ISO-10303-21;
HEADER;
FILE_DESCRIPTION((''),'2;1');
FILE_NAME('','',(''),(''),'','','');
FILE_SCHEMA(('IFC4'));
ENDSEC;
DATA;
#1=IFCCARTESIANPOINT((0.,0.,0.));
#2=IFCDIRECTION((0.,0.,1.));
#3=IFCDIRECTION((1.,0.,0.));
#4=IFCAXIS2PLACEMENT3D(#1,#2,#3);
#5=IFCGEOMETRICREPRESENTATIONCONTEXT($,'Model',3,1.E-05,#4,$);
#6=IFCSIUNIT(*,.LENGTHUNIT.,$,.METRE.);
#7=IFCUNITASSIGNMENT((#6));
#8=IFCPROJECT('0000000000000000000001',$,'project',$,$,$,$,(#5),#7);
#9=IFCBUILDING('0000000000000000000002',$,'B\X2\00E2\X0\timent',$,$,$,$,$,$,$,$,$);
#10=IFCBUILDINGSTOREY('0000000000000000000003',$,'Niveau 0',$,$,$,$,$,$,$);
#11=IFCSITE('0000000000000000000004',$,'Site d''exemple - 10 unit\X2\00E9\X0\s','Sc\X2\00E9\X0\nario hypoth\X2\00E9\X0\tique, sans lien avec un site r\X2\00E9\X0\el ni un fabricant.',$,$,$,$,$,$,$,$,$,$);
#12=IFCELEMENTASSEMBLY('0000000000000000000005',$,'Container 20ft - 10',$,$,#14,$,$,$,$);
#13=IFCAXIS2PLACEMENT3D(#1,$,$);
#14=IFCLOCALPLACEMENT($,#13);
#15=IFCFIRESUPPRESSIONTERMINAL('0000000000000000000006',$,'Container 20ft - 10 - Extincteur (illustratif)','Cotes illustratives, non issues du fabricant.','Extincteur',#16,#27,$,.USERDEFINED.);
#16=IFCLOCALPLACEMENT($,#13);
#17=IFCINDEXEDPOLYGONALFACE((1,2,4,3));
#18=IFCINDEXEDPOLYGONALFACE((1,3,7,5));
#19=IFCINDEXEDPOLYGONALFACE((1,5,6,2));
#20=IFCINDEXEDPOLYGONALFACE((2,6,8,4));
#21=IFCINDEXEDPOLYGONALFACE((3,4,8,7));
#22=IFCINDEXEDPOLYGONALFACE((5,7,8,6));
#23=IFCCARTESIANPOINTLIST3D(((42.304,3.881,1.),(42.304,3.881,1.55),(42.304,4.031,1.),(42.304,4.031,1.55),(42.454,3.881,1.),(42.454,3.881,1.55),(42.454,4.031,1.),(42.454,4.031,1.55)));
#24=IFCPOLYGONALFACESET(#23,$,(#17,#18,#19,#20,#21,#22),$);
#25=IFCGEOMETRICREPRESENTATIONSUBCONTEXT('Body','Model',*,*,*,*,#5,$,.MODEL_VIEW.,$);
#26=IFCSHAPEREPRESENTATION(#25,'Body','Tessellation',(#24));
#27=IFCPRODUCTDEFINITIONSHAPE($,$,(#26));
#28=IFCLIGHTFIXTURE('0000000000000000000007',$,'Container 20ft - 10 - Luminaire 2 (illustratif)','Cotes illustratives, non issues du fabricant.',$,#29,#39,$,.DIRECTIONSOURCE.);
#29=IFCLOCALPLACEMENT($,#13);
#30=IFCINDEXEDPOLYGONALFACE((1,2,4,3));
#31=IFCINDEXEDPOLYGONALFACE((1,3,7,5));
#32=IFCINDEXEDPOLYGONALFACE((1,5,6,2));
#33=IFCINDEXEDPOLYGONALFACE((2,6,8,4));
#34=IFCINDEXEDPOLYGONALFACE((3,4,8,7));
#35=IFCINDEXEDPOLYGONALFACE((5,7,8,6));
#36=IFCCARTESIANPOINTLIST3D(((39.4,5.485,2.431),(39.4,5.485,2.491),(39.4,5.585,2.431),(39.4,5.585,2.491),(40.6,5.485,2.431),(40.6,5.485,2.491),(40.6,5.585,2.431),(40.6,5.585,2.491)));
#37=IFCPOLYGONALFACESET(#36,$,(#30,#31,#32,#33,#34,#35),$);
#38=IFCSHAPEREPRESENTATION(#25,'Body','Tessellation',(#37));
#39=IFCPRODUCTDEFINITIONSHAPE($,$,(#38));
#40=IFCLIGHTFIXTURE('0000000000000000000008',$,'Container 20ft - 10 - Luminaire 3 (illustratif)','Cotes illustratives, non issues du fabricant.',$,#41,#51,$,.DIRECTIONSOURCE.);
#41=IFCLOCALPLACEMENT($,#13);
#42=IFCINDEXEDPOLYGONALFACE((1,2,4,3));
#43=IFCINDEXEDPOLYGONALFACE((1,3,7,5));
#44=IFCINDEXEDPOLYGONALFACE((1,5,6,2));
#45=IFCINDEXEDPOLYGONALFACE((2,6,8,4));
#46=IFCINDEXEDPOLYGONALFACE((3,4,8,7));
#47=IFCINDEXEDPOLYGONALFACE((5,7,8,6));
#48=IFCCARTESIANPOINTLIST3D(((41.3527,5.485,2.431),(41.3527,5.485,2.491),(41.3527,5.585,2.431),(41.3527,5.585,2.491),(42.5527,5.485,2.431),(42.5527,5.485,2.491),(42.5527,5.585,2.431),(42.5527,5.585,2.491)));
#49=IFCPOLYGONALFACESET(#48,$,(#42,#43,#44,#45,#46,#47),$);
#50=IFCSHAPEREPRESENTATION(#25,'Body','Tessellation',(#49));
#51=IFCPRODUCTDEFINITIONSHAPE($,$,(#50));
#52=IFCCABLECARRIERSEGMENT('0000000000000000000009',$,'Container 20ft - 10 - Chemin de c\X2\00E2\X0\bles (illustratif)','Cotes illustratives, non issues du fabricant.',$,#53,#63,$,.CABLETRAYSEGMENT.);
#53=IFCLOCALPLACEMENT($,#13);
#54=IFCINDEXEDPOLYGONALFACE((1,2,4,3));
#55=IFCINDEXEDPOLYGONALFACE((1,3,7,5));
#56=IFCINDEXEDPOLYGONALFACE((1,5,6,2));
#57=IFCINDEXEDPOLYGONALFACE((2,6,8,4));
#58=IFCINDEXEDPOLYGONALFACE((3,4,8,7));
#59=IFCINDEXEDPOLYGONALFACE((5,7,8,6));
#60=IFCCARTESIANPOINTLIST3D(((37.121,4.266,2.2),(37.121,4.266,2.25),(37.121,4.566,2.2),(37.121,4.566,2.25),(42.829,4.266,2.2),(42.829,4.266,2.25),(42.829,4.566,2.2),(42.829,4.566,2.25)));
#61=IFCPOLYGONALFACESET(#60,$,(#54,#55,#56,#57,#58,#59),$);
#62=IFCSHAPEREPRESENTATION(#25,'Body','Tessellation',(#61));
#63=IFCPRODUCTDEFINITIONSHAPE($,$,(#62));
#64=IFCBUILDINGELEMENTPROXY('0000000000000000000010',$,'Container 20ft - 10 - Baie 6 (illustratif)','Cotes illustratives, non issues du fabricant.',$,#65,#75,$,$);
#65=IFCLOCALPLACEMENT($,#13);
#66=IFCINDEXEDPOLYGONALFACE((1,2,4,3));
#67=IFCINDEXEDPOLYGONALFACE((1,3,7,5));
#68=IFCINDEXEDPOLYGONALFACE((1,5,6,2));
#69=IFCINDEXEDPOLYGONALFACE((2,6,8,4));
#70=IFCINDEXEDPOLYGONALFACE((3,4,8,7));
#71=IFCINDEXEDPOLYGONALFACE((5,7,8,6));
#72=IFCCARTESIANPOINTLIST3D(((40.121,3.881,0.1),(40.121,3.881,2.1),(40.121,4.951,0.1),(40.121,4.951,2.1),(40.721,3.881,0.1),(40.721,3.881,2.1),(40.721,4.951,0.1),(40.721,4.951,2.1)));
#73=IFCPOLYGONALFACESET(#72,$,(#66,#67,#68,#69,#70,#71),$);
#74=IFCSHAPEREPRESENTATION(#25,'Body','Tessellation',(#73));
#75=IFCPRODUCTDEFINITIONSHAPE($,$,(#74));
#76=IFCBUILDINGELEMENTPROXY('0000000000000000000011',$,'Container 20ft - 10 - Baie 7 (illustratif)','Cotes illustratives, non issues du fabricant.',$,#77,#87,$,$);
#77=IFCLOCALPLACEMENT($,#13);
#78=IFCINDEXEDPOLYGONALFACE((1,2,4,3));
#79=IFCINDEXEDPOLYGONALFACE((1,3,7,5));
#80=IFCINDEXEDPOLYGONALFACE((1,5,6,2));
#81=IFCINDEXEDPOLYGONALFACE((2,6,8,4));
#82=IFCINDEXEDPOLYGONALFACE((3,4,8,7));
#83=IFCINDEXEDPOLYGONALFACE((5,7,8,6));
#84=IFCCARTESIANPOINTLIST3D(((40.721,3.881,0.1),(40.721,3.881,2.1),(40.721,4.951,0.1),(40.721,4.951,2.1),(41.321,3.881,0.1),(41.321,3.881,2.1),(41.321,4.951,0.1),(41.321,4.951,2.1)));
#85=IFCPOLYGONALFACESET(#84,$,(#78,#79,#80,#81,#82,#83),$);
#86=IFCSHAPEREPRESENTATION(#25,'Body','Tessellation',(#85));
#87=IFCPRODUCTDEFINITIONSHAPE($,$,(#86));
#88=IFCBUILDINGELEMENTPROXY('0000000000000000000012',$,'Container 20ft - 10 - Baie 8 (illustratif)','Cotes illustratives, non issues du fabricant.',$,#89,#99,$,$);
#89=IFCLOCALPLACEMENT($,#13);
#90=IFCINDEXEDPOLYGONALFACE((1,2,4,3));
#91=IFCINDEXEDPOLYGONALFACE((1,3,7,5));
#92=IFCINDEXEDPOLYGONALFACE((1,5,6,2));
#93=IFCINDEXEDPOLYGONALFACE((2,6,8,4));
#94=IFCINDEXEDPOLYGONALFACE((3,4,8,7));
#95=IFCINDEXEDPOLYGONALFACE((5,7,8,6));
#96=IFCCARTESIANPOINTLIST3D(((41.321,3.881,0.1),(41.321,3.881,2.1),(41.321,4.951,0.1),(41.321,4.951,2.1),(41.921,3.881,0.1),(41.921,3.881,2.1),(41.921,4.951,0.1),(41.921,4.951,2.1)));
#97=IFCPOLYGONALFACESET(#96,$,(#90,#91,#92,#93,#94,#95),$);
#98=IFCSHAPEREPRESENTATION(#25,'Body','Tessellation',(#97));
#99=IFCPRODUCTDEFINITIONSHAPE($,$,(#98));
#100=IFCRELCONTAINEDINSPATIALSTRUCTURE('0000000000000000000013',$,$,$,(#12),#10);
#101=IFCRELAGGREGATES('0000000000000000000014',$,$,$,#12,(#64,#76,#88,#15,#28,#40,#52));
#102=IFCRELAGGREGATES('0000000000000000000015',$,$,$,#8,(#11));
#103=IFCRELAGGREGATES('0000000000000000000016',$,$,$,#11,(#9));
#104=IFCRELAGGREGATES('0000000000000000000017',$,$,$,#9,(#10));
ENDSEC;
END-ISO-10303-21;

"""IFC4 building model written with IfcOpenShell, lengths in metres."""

from ifc_helpers import new_model, si_unit, frame, origin_with_axes, place, context, subcontext, project, spatial, rectangle, extrude, element, aggregate, save


model = new_model("IFC4")

# Units and contexts
model_context = context("Model", 3, precision=1e-05, world=origin_with_axes())
body_context = subcontext(model_context, "Body", "Model", "MODEL_VIEW")
ifc_project = project(units=[si_unit("LENGTHUNIT", "METRE")], contexts=[model_context])

# Site, building, storey
site = spatial("IfcSite", under=ifc_project, Name="Site d'exemple - 10 unités", Description="Scénario hypothétique, sans lien avec un site réel ni un fabricant.")
building = spatial("IfcBuilding", under=site, Name="Bâtiment")
storey = spatial("IfcBuildingStorey", under=building, Name="Niveau 0")

# Element assembly, fire suppression terminal, light fixtures, cable carrier segment, building element proxies
assembly = element("IfcElementAssembly", 1, inside=storey, Name="Container 20ft - 10")
fire_suppression_terminal_placement = place(None, frame((42.379, 3.956, 1.0), z_axis=(0.0, 0.0, 1.0), x_axis=(1.0, 0.0, 0.0)))
fire_suppression_terminal = element("IfcFireSuppressionTerminal", 2, at=fire_suppression_terminal_placement, Name="Container 20ft - 10 - Extincteur (illustratif)", Description="Cotes illustratives, non issues du fabricant.", ObjectType="Extincteur", PredefinedType="USERDEFINED", context=body_context, shape_type="SweptSolid", body=[
    extrude(rectangle(XDim=0.15, YDim=0.15), origin_with_axes(), (0.0, 0.0, 1.0), 0.55),
])
light_fixture_1_placement = place(None, frame((40.0, 5.535, 2.431), z_axis=(0.0, 0.0, 1.0), x_axis=(1.0, 0.0, 0.0)))
light_fixture_1 = element("IfcLightFixture", 3, at=light_fixture_1_placement, Name="Container 20ft - 10 - Luminaire 2 (illustratif)", Description="Cotes illustratives, non issues du fabricant.", PredefinedType="DIRECTIONSOURCE", context=body_context, shape_type="SweptSolid", body=[
    extrude(rectangle(XDim=1.2, YDim=0.1), origin_with_axes(), (0.0, 0.0, 1.0), 0.06),
])
light_fixture_2_placement = place(None, frame((41.9527, 5.535, 2.431), z_axis=(0.0, 0.0, 1.0), x_axis=(1.0, 0.0, 0.0)))
light_fixture_2 = element("IfcLightFixture", 4, at=light_fixture_2_placement, Name="Container 20ft - 10 - Luminaire 3 (illustratif)", Description="Cotes illustratives, non issues du fabricant.", PredefinedType="DIRECTIONSOURCE", context=body_context, shape_type="SweptSolid", body=[
    extrude(rectangle(XDim=1.2, YDim=0.1), origin_with_axes(), (0.0, 0.0, 1.0), 0.06),
])
cable_carrier_segment_placement = place(None, frame((39.975, 4.416, 2.2), z_axis=(0.0, 0.0, 1.0), x_axis=(1.0, 0.0, 0.0)))
cable_carrier_segment = element("IfcCableCarrierSegment", 5, at=cable_carrier_segment_placement, Name="Container 20ft - 10 - Chemin de câbles (illustratif)", Description="Cotes illustratives, non issues du fabricant.", PredefinedType="CABLETRAYSEGMENT", context=body_context, shape_type="SweptSolid", body=[
    extrude(rectangle(XDim=5.708, YDim=0.3), origin_with_axes(), (0.0, 0.0, 1.0), 0.05),
])
proxy_1_placement = place(None, frame((40.421, 4.416, 0.1), z_axis=(0.0, 0.0, 1.0), x_axis=(1.0, 0.0, 0.0)))
proxy_1 = element("IfcBuildingElementProxy", 6, at=proxy_1_placement, Name="Container 20ft - 10 - Baie 6 (illustratif)", Description="Cotes illustratives, non issues du fabricant.", context=body_context, shape_type="SweptSolid", body=[
    extrude(rectangle(XDim=0.6, YDim=1.07), origin_with_axes(), (0.0, 0.0, 1.0), 2.0),
])
proxy_2_placement = place(None, frame((41.021, 4.416, 0.1), z_axis=(0.0, 0.0, 1.0), x_axis=(1.0, 0.0, 0.0)))
proxy_2 = element("IfcBuildingElementProxy", 7, at=proxy_2_placement, Name="Container 20ft - 10 - Baie 7 (illustratif)", Description="Cotes illustratives, non issues du fabricant.", context=body_context, shape_type="SweptSolid", body=[
    extrude(rectangle(XDim=0.6, YDim=1.07), origin_with_axes(), (0.0, 0.0, 1.0), 2.0),
])
proxy_3_placement = place(None, frame((41.621, 4.416, 0.1), z_axis=(0.0, 0.0, 1.0), x_axis=(1.0, 0.0, 0.0)))
proxy_3 = element("IfcBuildingElementProxy", 8, at=proxy_3_placement, Name="Container 20ft - 10 - Baie 8 (illustratif)", Description="Cotes illustratives, non issues du fabricant.", context=body_context, shape_type="SweptSolid", body=[
    extrude(rectangle(XDim=0.6, YDim=1.07), origin_with_axes(), (0.0, 0.0, 1.0), 2.0),
])
aggregate(assembly, [proxy_1, proxy_2, proxy_3, fire_suppression_terminal, light_fixture_1, light_fixture_2, cable_carrier_segment])

save(model, "model.ifc")
